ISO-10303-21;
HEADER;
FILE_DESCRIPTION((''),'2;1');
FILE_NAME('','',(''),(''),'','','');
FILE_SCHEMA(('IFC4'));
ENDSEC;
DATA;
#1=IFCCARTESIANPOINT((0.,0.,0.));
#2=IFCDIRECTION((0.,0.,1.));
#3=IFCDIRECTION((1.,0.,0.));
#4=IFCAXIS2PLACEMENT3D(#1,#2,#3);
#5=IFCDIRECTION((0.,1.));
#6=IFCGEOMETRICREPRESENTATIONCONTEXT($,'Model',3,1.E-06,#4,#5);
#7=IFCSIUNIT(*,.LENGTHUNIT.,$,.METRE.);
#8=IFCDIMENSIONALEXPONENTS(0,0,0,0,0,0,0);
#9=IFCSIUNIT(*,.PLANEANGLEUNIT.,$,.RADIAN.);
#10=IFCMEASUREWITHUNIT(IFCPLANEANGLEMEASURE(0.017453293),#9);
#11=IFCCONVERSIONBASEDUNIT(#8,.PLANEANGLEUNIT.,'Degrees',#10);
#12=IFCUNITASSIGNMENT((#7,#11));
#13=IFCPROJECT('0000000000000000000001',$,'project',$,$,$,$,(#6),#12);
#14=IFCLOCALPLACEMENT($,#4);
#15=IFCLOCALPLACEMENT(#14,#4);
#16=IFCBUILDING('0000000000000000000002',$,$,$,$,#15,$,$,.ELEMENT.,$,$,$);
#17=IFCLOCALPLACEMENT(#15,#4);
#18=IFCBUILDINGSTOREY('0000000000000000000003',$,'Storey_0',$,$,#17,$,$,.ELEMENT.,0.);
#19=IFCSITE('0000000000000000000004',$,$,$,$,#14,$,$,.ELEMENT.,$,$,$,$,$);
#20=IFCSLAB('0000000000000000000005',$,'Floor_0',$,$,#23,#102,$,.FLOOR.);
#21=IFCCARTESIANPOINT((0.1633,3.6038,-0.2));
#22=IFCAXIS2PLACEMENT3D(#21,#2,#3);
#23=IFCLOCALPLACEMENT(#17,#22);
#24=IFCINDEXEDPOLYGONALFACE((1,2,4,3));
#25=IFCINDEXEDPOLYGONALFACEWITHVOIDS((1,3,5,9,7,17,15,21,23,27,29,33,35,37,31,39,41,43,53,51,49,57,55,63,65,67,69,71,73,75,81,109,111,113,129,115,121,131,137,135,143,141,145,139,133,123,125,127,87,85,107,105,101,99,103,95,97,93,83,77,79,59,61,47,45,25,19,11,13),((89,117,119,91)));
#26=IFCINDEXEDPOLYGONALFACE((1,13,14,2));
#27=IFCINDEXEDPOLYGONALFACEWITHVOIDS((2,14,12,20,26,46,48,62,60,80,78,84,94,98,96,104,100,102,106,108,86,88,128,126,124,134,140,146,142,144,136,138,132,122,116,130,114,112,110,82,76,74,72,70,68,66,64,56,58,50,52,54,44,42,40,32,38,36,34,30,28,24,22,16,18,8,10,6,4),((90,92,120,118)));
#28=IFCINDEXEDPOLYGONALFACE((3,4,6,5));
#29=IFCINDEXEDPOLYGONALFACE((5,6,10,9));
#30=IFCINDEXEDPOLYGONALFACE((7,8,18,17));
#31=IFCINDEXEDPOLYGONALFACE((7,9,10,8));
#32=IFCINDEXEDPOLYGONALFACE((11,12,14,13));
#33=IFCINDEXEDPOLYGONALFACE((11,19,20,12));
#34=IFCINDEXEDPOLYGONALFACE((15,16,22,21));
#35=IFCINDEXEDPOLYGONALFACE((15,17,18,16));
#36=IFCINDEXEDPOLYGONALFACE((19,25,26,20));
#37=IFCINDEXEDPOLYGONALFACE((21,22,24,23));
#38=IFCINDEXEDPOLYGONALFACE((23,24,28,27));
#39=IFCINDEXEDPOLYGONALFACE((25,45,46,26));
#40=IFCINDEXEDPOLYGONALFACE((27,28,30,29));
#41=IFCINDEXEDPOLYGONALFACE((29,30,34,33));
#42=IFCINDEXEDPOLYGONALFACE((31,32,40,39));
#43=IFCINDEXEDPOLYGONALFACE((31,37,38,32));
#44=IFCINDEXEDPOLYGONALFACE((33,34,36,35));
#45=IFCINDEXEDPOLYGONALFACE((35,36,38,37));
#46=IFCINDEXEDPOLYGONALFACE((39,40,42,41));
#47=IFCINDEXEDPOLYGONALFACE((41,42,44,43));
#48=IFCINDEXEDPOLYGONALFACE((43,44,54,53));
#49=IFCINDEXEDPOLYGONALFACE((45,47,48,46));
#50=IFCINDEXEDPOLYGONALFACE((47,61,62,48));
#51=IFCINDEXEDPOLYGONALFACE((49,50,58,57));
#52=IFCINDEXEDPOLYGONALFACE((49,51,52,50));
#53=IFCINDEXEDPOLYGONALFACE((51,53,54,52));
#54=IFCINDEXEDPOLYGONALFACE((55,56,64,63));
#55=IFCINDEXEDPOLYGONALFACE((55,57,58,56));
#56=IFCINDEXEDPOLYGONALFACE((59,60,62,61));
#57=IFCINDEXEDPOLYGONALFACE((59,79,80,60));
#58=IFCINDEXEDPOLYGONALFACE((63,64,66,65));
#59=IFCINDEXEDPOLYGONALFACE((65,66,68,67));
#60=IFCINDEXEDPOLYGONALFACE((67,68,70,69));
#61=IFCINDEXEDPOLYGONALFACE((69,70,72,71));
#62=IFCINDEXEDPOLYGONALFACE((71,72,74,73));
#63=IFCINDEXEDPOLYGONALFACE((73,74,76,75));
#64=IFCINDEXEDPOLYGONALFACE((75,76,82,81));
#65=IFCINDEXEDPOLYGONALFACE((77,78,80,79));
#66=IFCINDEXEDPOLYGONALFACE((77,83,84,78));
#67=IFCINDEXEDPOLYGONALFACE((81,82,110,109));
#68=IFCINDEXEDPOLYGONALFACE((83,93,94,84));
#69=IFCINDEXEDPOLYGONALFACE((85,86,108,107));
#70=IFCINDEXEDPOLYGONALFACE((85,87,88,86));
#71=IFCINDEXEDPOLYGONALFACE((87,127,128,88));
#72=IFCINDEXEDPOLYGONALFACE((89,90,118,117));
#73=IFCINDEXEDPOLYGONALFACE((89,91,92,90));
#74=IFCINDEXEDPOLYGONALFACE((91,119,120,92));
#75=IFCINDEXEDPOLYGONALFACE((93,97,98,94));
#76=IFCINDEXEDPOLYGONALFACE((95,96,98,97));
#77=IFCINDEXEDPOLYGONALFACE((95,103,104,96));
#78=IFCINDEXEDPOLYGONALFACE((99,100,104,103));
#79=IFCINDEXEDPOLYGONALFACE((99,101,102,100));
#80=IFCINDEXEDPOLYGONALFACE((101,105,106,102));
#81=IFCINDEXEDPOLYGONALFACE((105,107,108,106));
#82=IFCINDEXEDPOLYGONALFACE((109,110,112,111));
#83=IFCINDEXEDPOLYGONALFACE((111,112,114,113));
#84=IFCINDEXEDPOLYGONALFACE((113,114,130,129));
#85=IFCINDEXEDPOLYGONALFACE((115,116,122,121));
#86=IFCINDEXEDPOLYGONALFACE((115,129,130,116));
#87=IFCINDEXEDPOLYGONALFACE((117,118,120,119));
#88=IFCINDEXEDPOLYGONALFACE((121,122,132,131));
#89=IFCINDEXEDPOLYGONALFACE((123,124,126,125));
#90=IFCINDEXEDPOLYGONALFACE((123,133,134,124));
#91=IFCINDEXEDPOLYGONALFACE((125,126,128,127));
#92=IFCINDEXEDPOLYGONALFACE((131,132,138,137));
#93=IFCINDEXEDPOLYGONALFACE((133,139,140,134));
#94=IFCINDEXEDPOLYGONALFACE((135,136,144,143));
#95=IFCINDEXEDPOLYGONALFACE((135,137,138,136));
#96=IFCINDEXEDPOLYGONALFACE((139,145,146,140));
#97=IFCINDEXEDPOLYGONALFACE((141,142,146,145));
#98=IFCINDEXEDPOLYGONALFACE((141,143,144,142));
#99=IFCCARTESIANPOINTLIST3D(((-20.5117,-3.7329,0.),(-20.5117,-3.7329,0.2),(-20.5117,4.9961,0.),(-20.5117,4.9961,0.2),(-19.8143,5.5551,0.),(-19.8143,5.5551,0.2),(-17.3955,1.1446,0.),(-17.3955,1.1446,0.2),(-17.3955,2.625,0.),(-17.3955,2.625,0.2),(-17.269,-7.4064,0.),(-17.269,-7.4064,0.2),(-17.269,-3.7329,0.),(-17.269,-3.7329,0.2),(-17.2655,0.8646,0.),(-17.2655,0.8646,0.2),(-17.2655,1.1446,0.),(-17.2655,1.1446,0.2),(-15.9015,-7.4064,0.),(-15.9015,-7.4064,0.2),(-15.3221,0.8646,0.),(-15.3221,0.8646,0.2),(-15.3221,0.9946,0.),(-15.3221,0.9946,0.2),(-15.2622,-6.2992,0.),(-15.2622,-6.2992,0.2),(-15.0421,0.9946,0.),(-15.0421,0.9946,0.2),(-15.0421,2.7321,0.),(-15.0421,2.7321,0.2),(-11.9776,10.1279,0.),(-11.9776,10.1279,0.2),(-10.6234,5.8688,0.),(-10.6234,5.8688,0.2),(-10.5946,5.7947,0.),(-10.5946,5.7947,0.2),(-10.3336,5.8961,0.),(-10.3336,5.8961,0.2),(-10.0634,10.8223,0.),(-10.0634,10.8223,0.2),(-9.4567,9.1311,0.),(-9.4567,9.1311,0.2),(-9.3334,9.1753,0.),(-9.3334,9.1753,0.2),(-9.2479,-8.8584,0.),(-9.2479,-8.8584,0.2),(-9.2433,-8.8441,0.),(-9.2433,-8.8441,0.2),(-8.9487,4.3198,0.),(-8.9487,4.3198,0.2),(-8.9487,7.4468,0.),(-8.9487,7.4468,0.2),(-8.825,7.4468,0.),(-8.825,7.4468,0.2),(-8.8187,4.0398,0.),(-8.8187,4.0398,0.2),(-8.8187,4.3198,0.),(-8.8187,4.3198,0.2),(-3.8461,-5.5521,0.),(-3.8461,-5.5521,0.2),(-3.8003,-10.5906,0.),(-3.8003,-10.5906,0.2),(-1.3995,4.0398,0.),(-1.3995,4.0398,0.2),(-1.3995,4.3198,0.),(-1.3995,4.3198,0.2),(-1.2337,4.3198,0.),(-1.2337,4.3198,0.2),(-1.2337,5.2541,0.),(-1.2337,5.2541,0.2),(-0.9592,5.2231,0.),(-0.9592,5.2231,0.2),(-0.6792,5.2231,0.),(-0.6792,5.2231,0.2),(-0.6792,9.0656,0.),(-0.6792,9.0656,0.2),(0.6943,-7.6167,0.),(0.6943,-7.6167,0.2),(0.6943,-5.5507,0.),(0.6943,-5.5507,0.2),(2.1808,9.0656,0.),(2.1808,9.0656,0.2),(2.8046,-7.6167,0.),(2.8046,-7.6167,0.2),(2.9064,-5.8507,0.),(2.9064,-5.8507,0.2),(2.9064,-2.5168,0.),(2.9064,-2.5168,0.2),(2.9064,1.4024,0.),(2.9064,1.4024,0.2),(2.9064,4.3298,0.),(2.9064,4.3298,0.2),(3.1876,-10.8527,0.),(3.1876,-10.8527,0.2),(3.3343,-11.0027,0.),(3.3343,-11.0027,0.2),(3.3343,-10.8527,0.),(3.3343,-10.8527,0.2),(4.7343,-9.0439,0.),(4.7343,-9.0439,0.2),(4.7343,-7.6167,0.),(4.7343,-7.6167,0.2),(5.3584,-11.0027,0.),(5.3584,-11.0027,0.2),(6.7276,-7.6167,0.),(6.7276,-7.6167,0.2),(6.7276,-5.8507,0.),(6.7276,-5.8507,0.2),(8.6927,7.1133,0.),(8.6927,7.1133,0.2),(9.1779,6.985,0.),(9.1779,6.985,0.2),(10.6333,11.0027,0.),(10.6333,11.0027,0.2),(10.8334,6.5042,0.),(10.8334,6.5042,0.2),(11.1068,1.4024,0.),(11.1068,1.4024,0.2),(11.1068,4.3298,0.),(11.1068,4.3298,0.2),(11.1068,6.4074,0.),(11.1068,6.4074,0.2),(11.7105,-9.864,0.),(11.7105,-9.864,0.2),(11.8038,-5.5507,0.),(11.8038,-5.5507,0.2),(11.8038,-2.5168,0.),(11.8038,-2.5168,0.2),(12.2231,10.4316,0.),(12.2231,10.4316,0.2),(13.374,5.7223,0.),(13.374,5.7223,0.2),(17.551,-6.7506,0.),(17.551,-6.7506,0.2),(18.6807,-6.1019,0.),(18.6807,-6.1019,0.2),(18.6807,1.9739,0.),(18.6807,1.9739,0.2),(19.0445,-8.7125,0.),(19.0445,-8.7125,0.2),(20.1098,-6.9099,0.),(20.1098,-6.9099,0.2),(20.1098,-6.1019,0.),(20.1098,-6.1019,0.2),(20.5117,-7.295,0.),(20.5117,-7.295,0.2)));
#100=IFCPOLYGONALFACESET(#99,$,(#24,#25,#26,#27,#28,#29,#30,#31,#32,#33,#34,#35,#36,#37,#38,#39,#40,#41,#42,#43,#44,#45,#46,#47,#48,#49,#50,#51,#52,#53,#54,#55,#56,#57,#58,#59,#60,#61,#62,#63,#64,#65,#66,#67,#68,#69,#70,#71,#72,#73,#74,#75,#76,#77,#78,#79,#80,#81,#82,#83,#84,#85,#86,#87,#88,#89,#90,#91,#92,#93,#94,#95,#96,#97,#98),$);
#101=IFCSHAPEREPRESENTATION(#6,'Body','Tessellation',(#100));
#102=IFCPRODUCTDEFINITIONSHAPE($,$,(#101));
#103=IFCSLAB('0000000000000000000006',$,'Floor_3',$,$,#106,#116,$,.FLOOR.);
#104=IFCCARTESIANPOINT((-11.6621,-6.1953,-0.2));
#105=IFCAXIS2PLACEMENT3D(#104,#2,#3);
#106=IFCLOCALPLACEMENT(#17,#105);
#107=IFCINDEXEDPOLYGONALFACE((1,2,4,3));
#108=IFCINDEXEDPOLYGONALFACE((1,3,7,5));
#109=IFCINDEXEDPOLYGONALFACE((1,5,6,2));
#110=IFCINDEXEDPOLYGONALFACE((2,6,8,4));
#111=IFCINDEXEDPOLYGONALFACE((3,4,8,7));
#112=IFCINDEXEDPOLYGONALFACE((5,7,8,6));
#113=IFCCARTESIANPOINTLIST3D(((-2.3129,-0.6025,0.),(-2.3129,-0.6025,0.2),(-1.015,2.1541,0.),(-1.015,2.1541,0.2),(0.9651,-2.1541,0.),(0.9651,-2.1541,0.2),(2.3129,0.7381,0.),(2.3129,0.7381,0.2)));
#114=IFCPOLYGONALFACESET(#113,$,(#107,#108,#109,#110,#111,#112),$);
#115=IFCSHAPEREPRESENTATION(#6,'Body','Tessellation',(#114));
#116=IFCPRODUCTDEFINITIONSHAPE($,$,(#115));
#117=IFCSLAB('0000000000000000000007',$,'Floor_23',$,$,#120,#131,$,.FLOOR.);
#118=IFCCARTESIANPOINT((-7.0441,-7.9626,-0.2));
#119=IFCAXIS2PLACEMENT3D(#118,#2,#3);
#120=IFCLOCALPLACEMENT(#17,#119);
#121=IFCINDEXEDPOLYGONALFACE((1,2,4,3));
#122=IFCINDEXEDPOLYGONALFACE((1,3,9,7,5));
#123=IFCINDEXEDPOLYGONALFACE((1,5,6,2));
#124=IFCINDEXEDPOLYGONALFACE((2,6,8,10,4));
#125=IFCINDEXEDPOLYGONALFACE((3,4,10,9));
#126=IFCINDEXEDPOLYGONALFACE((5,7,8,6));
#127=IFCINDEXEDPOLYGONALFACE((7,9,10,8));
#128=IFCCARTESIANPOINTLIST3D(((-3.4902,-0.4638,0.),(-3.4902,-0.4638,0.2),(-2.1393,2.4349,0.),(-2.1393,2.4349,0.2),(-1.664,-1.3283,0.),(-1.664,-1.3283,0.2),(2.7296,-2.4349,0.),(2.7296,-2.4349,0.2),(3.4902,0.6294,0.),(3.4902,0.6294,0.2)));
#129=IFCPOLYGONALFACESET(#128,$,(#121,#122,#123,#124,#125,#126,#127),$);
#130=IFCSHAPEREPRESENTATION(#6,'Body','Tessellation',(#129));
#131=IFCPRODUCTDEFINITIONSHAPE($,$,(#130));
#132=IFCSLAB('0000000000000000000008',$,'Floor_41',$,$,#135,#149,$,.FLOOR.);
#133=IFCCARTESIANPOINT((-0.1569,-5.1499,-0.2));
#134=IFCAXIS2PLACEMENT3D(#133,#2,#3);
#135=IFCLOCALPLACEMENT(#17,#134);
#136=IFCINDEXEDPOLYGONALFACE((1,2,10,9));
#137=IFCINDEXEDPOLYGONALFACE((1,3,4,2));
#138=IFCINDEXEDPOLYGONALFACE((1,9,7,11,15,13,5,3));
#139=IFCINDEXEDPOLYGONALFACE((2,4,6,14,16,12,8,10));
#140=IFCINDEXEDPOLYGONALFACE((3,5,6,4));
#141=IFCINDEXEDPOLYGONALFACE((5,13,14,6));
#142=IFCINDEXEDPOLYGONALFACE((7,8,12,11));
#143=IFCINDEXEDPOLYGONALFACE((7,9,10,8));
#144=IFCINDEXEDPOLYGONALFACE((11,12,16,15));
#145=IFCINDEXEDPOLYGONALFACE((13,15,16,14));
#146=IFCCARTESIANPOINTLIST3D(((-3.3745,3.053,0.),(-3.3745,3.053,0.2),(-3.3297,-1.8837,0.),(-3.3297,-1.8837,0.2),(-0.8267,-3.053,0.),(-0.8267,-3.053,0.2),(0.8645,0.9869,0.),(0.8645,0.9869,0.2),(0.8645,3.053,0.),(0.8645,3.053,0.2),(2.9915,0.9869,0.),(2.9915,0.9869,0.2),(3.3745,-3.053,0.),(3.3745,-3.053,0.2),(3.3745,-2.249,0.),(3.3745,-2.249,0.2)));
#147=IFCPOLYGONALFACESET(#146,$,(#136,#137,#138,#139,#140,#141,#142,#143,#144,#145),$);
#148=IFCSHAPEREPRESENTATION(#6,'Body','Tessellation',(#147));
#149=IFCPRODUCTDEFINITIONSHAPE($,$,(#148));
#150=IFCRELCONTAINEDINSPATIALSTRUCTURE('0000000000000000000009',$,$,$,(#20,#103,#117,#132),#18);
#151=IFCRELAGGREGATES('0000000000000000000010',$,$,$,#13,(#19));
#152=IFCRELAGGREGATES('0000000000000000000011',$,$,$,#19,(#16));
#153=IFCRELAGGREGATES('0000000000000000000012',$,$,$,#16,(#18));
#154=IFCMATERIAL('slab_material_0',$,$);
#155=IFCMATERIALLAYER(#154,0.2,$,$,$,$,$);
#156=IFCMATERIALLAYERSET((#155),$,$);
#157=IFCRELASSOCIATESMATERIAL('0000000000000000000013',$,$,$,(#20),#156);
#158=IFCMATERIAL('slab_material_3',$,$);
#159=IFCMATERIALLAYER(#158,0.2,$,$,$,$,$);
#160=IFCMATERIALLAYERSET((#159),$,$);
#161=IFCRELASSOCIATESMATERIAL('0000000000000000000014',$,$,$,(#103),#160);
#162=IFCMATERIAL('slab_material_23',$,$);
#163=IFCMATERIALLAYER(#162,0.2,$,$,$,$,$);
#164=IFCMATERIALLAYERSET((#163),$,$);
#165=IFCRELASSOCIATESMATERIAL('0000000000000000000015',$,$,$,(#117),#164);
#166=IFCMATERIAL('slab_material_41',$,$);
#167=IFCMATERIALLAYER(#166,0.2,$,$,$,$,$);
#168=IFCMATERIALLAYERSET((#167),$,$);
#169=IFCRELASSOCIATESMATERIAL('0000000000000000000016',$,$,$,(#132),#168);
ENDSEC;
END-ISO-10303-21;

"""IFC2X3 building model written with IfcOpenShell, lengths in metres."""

from ifc_helpers import new_model, entity, si_unit, converted_unit, direction, frame, origin_with_axes, place, context, project, spatial, polyline, outline, extrude, material, layer, layer_set, layer_usage, element, save


model = new_model("IFC2X3")

# Units and contexts
model_context = context("Model", 3, precision=1e-06, world=origin_with_axes(), true_north=direction((0.0, 1.0)))
ifc_project = project(units=[si_unit("LENGTHUNIT", "METRE"), converted_unit("PLANEANGLEUNIT", "Degrees", entity("IfcPlaneAngleMeasure", 0.017453293), si_unit("PLANEANGLEUNIT", "RADIAN"), dimensions=[0, 0, 0, 0, 0, 0, 0])], contexts=[model_context])

# Site, building, storey
site_placement = place(None, origin_with_axes())
site = spatial("IfcSite", under=ifc_project, at=site_placement, CompositionType="ELEMENT")
building_placement = place(site_placement, origin_with_axes())
building = spatial("IfcBuilding", under=site, at=building_placement, CompositionType="ELEMENT")
storey_placement = place(building_placement, origin_with_axes())
storey = spatial("IfcBuildingStorey", under=building, at=storey_placement, Name="Storey_0", CompositionType="ELEMENT", Elevation=0.0)

# Slab, opening
ifc_material_1 = material(Name="slab_material_0")
ifc_layer_1 = layer(ifc_material_1, 0.2)
ifc_layer_set_1 = layer_set([ifc_layer_1])
ifc_layer_usage_1 = layer_usage(ifc_layer_set_1, "AXIS3", "POSITIVE", 0.0)
slab_1_placement = place(storey_placement, frame((0.1633, 3.6038, -0.2), z_axis=(0.0, 0.0, 1.0), x_axis=(1.0, 0.0, 0.0)))
slab_1 = element("IfcSlab", 1, at=slab_1_placement, inside=storey, material=ifc_layer_usage_1, Name="Floor_0", PredefinedType="FLOOR", context=model_context, shape_type="SweptSolid", body=[
    extrude(outline(polyline([(20.5117, -7.295), (19.0445, -8.7125), (17.551, -6.7506), (11.7105, -9.864), (11.8038, -5.5507), (11.8038, -2.5168), (2.9064, -2.5168), (2.9064, -5.8507), (6.7276, -5.8507), (6.7276, -7.6167), (4.7343, -7.6167), (4.7343, -9.0439), (5.3584, -11.0027), (3.3343, -11.0027), (3.3343, -10.8527), (3.1876, -10.8527), (2.8046, -7.6167), (0.6943, -7.6167), (0.6943, -5.5507), (-3.8461, -5.5521), (-3.8003, -10.5906), (-9.2433, -8.8441), (-9.2479, -8.8584), (-15.2622, -6.2992), (-15.9015, -7.4064), (-17.269, -7.4064), (-17.269, -3.7329), (-20.5117, -3.7329), (-20.5117, 4.9961), (-19.8143, 5.5551), (-17.3955, 2.625), (-17.3955, 1.1446), (-17.2655, 1.1446), (-17.2655, 0.8646), (-15.3221, 0.8646), (-15.3221, 0.9946), (-15.0421, 0.9946), (-15.0421, 2.7321), (-10.6234, 5.8688), (-10.5946, 5.7947), (-10.3336, 5.8961), (-11.9776, 10.1279), (-10.0634, 10.8223), (-9.4567, 9.1311), (-9.3334, 9.1753), (-8.825, 7.4468), (-8.9487, 7.4468), (-8.9487, 4.3198), (-8.8187, 4.3198), (-8.8187, 4.0398), (-1.3995, 4.0398), (-1.3995, 4.3198), (-1.2337, 4.3198), (-1.2337, 5.2541), (-0.9592, 5.2231), (-0.6792, 5.2231), (-0.6792, 9.0656), (2.1808, 9.0656), (8.6927, 7.1133), (9.1779, 6.985), (10.6333, 11.0027), (12.2231, 10.4316), (10.8334, 6.5042), (11.1068, 6.4074), (13.374, 5.7223), (18.6807, 1.9739), (18.6807, -6.1019), (20.1098, -6.1019), (20.1098, -6.9099), (20.5117, -7.295)])), origin_with_axes(), (0.0, 0.0, 1.0), 0.2),
])
opening_1_placement = place(slab_1_placement, origin_with_axes())
element("IfcOpeningElement", 2, at=opening_1_placement, cuts=slab_1, context=model_context, shape_type="SweptSolid", body=[
    extrude(outline(polyline([(11.1068, 4.3198), (2.9064, 4.3198), (2.9064, 1.3924), (11.1068, 1.3924), (11.1068, 4.3198)])), frame((0.0, 0.01, 0.0), z_axis=(0.0, 0.0, 1.0), x_axis=(1.0, 0.0, 0.0)), (0.0, 0.0, 1.0), 0.22),
])

# Slabs
ifc_material_2 = material(Name="slab_material_3")
ifc_layer_2 = layer(ifc_material_2, 0.2)
ifc_layer_set_2 = layer_set([ifc_layer_2])
ifc_layer_usage_2 = layer_usage(ifc_layer_set_2, "AXIS3", "POSITIVE", 0.0)
slab_2_placement = place(storey_placement, frame((-11.6621, -6.1953, -0.2), z_axis=(0.0, 0.0, 1.0), x_axis=(1.0, 0.0, 0.0)))
element("IfcSlab", 3, at=slab_2_placement, inside=storey, material=ifc_layer_usage_2, Name="Floor_3", PredefinedType="FLOOR", context=model_context, shape_type="SweptSolid", body=[
    extrude(outline(polyline([(2.3129, 0.7381), (0.9651, -2.1541), (-2.3129, -0.6025), (-1.015, 2.1541), (2.3129, 0.7381)])), origin_with_axes(), (0.0, 0.0, 1.0), 0.2),
])
ifc_material_3 = material(Name="slab_material_23")
ifc_layer_3 = layer(ifc_material_3, 0.2)
ifc_layer_set_3 = layer_set([ifc_layer_3])
ifc_layer_usage_3 = layer_usage(ifc_layer_set_3, "AXIS3", "POSITIVE", 0.0)
slab_3_placement = place(storey_placement, frame((-7.0441, -7.9626, -0.2), z_axis=(0.0, 0.0, 1.0), x_axis=(1.0, 0.0, 0.0)))
element("IfcSlab", 4, at=slab_3_placement, inside=storey, material=ifc_layer_usage_3, Name="Floor_23", PredefinedType="FLOOR", context=model_context, shape_type="SweptSolid", body=[
    extrude(outline(polyline([(-2.1393, 2.4349), (3.4902, 0.6294), (2.7296, -2.4349), (-1.664, -1.3283), (-3.4902, -0.4638), (-2.1393, 2.4349)])), origin_with_axes(), (0.0, 0.0, 1.0), 0.2),
])
ifc_material_4 = material(Name="slab_material_41")
ifc_layer_4 = layer(ifc_material_4, 0.2)
ifc_layer_set_4 = layer_set([ifc_layer_4])
ifc_layer_usage_4 = layer_usage(ifc_layer_set_4, "AXIS3", "POSITIVE", 0.0)
slab_4_placement = place(storey_placement, frame((-0.1569, -5.1499, -0.2), z_axis=(0.0, 0.0, 1.0), x_axis=(1.0, 0.0, 0.0)))
element("IfcSlab", 5, at=slab_4_placement, inside=storey, material=ifc_layer_usage_4, Name="Floor_41", PredefinedType="FLOOR", context=model_context, shape_type="SweptSolid", body=[
    extrude(outline(polyline([(0.8645, 3.053), (0.8645, 0.9869), (2.9915, 0.9869), (3.3745, -2.249), (3.3745, -3.053), (-0.8267, -3.053), (-3.3297, -1.8837), (-3.3745, 3.053), (0.8645, 3.053)])), origin_with_axes(), (0.0, 0.0, 1.0), 0.2),
])

save(model, "model.ifc")
